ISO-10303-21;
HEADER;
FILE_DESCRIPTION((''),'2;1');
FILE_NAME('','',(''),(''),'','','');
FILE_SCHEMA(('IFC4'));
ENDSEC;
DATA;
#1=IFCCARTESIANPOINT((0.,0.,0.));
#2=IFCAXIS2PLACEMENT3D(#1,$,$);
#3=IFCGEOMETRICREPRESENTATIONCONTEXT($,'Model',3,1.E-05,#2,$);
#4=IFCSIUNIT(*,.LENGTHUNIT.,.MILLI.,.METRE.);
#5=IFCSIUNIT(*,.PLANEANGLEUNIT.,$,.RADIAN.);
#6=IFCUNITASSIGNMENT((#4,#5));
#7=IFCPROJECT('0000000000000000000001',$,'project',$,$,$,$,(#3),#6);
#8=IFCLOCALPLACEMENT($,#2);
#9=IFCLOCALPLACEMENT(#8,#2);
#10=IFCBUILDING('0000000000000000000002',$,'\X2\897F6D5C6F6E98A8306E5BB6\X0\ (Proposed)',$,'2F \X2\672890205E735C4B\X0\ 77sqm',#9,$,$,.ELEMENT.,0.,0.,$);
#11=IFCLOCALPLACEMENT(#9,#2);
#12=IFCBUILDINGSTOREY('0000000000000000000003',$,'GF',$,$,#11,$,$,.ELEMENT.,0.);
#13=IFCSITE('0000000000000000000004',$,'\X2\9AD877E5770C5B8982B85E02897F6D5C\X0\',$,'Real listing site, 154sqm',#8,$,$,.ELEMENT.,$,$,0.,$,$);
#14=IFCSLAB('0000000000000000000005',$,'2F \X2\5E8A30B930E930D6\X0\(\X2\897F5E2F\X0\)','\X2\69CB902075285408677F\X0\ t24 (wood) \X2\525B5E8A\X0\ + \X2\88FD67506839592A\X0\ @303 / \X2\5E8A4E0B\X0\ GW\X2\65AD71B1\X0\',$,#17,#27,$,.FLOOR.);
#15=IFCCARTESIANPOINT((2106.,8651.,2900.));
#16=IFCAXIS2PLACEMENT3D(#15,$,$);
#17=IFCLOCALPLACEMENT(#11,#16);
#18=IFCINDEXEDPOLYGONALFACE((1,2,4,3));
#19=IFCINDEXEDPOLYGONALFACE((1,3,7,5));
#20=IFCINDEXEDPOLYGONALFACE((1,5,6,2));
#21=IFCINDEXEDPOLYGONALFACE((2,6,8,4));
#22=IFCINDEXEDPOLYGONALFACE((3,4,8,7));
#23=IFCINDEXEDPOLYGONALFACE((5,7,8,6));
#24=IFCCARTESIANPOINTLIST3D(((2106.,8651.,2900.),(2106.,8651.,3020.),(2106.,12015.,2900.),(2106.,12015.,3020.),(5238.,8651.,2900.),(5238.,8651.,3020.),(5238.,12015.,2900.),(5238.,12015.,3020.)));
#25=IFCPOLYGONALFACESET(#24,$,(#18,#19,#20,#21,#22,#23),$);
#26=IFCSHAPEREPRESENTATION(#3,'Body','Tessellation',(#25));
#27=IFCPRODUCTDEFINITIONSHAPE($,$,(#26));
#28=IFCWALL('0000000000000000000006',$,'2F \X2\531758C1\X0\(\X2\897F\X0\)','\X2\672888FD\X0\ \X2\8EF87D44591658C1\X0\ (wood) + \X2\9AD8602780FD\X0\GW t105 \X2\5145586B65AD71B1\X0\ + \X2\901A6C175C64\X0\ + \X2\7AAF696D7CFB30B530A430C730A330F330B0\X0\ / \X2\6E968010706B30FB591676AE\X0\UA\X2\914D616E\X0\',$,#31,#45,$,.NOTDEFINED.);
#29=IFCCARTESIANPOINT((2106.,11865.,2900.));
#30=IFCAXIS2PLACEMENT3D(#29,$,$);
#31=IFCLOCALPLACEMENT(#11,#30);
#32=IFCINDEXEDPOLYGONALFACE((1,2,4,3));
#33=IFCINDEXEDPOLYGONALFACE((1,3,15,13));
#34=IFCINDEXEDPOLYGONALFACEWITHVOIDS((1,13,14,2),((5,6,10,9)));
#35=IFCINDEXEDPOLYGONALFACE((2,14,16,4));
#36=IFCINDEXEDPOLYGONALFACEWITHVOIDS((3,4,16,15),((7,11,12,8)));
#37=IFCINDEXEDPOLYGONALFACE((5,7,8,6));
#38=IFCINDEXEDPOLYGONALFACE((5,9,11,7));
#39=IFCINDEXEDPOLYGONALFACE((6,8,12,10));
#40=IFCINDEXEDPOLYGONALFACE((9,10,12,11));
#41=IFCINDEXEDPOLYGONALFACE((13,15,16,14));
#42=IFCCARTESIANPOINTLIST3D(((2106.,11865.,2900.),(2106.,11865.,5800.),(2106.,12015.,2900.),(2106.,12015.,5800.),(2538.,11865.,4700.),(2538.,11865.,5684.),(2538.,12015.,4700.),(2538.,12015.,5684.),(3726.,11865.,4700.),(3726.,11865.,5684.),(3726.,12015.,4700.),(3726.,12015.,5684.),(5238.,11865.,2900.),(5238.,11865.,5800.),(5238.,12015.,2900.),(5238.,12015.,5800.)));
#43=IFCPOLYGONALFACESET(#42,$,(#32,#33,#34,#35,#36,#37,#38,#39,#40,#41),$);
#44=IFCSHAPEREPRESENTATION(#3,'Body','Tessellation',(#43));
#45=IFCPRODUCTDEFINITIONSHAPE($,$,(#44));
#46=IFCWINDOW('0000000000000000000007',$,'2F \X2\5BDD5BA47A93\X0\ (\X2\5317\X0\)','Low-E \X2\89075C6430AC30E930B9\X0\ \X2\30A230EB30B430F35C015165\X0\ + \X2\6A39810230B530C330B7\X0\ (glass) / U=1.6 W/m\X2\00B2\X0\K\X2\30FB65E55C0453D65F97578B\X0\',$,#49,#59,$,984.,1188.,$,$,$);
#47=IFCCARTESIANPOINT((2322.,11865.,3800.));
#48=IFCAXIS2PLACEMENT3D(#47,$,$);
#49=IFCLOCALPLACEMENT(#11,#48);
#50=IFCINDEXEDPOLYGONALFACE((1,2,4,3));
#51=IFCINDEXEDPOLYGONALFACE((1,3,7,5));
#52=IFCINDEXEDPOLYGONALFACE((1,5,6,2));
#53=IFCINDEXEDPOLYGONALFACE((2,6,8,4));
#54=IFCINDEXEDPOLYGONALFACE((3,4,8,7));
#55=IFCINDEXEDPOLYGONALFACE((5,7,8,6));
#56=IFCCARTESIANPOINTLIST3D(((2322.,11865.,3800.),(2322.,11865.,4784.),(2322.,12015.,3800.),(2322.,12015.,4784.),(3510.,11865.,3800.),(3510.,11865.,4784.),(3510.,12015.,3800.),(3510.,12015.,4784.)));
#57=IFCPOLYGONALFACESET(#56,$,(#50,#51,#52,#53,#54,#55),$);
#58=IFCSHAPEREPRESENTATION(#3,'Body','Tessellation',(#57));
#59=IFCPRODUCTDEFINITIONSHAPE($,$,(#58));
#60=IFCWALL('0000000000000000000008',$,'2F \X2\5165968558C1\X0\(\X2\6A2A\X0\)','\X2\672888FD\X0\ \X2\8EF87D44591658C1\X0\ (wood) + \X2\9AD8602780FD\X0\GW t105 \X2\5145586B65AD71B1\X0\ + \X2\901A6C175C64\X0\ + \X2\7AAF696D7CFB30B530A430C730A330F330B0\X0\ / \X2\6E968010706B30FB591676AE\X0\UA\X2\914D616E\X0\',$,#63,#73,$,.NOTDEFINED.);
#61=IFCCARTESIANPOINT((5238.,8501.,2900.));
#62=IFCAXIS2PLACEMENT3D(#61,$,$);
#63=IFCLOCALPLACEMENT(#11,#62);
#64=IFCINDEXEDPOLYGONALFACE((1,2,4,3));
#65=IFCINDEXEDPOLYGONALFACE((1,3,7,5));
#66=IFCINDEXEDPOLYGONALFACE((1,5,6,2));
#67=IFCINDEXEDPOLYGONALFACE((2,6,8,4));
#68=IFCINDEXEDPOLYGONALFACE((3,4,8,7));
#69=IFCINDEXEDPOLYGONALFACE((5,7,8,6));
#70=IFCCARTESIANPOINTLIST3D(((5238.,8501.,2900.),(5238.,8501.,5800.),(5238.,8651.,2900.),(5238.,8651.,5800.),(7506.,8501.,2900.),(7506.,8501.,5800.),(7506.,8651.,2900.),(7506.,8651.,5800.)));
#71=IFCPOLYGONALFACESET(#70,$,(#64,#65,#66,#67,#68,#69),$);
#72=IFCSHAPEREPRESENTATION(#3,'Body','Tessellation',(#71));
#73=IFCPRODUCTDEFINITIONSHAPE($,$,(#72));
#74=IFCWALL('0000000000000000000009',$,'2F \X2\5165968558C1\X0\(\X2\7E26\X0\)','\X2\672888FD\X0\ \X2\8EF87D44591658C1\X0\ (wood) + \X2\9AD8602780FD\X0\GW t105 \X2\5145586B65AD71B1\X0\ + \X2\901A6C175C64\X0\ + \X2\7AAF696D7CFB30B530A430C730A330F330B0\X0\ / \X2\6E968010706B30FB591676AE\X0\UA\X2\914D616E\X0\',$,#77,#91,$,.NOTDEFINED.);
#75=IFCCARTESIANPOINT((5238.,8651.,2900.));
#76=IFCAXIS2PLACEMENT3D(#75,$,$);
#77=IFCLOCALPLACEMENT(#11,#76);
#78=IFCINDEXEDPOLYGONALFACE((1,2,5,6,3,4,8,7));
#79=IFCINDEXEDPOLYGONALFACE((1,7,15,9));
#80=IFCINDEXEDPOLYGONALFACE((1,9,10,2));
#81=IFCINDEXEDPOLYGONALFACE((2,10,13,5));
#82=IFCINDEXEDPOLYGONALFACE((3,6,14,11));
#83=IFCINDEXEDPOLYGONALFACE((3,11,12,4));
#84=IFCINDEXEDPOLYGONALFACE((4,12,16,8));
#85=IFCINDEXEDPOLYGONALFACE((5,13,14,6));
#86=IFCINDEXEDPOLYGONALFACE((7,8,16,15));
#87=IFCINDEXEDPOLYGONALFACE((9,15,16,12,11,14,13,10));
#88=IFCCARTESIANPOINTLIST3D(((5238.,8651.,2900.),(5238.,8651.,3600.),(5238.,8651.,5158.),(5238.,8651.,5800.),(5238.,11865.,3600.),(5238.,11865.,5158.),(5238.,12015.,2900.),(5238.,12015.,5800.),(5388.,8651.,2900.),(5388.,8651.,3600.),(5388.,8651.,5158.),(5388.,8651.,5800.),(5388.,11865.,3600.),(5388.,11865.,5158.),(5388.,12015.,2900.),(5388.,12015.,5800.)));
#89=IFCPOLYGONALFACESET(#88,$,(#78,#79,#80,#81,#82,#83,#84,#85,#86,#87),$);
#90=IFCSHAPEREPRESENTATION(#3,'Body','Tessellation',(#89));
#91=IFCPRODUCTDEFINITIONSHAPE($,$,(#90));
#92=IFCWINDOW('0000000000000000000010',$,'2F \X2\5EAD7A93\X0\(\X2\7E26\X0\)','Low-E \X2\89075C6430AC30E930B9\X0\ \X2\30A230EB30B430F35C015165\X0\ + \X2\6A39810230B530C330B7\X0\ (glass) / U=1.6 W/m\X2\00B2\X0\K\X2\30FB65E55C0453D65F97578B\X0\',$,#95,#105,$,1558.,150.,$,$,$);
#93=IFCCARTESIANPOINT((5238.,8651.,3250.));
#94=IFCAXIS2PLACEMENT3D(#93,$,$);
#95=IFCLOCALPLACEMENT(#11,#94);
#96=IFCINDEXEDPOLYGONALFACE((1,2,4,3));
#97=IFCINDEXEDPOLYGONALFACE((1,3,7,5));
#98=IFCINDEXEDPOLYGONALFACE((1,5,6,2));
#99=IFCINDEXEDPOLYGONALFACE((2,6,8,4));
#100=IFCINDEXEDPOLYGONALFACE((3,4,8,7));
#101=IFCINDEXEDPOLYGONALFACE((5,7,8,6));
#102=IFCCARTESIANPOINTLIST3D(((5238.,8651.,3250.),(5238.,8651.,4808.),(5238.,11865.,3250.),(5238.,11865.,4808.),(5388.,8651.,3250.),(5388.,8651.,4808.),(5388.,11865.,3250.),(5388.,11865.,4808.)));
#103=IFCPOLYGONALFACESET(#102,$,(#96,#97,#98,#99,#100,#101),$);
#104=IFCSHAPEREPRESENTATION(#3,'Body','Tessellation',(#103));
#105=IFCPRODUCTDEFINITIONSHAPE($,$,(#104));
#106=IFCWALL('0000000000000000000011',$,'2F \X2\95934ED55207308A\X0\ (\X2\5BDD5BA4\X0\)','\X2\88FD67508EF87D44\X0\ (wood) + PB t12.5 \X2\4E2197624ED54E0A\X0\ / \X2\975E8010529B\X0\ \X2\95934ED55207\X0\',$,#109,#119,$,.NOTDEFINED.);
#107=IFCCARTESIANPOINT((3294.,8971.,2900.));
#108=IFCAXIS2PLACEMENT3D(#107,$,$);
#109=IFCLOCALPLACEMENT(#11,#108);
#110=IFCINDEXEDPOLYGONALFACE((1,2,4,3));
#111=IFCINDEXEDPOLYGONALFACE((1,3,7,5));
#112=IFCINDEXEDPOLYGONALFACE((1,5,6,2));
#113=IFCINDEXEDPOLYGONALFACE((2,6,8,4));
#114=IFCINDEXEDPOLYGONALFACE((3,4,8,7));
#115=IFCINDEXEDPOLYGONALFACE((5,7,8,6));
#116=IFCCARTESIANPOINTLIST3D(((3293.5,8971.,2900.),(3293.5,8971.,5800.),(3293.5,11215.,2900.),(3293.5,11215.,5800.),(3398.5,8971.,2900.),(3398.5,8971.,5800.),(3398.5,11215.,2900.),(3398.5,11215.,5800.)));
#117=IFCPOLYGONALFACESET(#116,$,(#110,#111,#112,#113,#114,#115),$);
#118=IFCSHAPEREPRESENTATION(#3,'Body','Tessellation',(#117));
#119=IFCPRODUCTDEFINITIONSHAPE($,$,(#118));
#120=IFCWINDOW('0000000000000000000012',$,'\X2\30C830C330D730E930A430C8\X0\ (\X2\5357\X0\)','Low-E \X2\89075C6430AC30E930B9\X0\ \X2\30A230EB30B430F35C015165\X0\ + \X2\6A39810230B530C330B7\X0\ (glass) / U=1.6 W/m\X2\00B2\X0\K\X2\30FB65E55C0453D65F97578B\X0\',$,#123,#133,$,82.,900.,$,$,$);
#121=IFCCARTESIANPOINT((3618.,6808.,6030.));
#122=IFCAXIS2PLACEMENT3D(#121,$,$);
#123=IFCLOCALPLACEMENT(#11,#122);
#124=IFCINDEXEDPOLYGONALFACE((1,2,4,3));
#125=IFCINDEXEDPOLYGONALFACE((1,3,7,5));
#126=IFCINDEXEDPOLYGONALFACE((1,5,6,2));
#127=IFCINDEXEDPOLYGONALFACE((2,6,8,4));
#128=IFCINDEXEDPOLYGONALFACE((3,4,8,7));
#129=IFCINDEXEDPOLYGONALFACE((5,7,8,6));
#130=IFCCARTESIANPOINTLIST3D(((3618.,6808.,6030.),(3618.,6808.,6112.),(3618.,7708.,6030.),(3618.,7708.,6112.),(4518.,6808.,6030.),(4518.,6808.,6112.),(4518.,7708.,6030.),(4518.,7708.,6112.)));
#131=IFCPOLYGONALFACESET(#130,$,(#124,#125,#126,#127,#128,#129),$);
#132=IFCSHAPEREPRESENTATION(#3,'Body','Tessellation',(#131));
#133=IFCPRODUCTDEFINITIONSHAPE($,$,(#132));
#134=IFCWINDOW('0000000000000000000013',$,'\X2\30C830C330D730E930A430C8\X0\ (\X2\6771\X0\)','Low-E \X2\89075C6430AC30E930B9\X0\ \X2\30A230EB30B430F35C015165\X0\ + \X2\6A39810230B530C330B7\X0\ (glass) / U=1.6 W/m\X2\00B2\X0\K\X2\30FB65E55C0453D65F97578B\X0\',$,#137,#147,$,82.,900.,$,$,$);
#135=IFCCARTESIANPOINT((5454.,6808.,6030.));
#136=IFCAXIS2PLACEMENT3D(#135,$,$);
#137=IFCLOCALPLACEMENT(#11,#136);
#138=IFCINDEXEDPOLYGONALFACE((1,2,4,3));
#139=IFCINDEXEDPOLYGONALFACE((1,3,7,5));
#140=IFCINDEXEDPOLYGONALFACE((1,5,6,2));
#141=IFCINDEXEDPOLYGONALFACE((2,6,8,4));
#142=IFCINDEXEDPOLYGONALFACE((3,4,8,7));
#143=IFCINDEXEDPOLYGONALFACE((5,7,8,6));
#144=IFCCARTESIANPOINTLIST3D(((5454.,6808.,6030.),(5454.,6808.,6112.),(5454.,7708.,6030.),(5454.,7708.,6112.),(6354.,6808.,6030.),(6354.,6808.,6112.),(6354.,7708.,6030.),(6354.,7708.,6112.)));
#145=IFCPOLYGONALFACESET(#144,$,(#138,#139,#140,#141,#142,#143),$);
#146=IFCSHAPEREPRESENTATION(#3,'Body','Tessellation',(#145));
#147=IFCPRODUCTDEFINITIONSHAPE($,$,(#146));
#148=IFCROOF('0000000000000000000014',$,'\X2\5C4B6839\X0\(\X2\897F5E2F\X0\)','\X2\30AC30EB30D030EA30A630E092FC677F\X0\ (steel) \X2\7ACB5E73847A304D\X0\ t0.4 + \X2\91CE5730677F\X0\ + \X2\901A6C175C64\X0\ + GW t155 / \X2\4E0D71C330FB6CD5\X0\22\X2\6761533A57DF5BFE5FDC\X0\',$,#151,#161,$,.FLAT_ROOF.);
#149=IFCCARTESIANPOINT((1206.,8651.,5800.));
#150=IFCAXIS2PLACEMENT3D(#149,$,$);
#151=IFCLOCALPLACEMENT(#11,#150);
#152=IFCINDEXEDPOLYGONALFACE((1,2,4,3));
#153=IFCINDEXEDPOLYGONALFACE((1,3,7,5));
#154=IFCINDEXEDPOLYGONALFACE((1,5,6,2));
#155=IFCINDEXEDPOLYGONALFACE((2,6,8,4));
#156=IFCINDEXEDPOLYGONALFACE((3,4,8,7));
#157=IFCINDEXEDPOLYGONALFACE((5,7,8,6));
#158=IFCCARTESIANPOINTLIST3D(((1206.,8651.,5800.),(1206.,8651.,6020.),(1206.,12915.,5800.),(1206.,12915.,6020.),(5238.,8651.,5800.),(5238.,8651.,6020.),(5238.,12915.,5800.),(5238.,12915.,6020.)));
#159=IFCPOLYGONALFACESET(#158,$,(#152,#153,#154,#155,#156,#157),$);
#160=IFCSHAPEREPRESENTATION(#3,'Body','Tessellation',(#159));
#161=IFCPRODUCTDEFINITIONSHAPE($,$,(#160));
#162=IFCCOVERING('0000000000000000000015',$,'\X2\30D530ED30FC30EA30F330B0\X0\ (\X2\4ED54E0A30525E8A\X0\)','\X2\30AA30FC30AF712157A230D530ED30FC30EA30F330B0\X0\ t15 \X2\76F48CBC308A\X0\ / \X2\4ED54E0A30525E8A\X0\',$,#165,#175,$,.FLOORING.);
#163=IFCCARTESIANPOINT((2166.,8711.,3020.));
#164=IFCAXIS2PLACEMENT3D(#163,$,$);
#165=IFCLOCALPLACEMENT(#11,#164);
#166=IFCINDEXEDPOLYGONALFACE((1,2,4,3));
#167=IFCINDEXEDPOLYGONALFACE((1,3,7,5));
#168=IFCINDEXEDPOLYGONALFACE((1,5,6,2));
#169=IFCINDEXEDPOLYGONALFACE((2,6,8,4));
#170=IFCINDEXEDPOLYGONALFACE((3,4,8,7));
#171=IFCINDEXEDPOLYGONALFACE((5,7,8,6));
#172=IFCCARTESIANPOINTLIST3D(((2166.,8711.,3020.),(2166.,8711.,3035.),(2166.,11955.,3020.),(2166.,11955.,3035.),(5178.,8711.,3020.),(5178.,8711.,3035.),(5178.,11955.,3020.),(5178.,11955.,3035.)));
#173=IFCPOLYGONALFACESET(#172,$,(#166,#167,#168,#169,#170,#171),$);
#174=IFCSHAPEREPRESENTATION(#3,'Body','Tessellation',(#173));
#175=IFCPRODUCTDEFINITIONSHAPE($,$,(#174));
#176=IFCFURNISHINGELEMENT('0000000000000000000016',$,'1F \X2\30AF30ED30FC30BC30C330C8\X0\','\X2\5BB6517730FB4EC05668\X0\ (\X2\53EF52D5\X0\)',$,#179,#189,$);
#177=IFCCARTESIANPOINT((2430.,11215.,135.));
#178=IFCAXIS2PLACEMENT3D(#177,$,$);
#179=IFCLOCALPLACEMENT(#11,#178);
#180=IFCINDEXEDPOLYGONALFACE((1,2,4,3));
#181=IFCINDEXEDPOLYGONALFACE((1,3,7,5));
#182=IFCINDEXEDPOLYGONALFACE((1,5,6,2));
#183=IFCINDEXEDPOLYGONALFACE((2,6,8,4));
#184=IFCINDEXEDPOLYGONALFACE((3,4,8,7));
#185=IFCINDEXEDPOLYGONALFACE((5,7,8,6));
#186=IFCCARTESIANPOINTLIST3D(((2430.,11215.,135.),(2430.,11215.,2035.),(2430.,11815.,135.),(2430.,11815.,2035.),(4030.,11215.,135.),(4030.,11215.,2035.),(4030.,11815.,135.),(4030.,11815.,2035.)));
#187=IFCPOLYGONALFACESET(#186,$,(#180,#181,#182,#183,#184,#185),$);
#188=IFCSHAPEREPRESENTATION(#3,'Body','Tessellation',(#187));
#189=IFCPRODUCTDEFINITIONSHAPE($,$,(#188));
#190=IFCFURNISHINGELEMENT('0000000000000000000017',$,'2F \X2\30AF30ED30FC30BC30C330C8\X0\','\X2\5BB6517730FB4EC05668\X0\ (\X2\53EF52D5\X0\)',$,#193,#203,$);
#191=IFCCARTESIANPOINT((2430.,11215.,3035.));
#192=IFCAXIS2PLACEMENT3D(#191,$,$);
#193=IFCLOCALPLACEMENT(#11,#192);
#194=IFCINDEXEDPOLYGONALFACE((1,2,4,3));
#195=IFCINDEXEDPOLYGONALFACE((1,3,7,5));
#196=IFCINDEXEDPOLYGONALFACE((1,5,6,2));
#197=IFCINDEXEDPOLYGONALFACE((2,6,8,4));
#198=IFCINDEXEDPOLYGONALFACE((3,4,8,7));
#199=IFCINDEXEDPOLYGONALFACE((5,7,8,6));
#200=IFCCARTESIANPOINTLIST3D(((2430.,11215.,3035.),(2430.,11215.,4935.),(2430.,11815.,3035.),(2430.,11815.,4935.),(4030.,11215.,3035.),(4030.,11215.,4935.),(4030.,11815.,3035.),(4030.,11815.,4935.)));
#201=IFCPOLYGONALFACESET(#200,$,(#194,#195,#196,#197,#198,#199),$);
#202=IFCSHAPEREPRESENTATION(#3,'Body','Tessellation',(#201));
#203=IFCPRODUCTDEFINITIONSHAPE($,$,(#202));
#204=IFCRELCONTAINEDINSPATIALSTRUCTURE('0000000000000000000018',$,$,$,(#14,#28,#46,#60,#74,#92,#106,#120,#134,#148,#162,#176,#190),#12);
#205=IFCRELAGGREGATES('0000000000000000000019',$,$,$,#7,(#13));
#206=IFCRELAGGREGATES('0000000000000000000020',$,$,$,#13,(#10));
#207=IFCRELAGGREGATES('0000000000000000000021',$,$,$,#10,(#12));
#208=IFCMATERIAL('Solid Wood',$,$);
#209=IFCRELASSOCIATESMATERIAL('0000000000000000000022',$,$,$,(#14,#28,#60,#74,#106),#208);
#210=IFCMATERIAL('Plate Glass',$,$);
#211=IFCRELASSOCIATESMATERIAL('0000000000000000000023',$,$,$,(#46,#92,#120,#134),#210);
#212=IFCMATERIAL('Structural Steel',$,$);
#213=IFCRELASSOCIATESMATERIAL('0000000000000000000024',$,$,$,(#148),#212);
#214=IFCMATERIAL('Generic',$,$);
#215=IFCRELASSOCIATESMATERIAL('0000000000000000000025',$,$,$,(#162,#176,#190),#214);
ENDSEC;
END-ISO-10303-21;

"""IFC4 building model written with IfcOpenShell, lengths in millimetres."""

from ifc_helpers import new_model, si_unit, frame, frame_2d, origin, place, context, project, spatial, rectangle, extrude, material, element, fill, save


model = new_model("IFC4")

# Units and contexts
model_context = context("Model", 3, precision=1e-05, world=origin())
ifc_project = project(units=[si_unit("LENGTHUNIT", "METRE", prefix="MILLI"), si_unit("PLANEANGLEUNIT", "RADIAN")], contexts=[model_context])

# Site, building, storey
site_placement = place(None, origin())
site = spatial("IfcSite", under=ifc_project, at=site_placement, Name="高知県安芸市西浜", ObjectType="Real listing site, 154sqm", CompositionType="ELEMENT", RefElevation=0.0)
building_placement = place(site_placement, origin())
building = spatial("IfcBuilding", under=site, at=building_placement, Name="西浜潮風の家 (Proposed)", ObjectType="2F 木造平屋 77sqm", CompositionType="ELEMENT", ElevationOfRefHeight=0.0, ElevationOfTerrain=0.0)
storey_placement = place(building_placement, origin())
storey = spatial("IfcBuildingStorey", under=building, at=storey_placement, Name="GF", CompositionType="ELEMENT", Elevation=0.0)

# Slab
ifc_material_1 = material(Name="Solid Wood")
slab_placement = place(storey_placement, frame((2106.0, 8651.0, 2900.0)))
element("IfcSlab", 1, at=slab_placement, inside=storey, material=ifc_material_1, Name="2F 床スラブ(西帯)", Description="構造用合板 t24 (wood) 剛床 + 製材根太 @303 / 床下 GW断熱", PredefinedType="FLOOR", context=model_context, shape_type="SweptSolid", body=[
    extrude(rectangle(XDim=3132.0, YDim=3364.0, at=frame_2d((1566.0, 1682.0))), frame((2106.0, 8651.0, 2900.0)), (0.0, 0.0, 1.0), 120.0),
])

# Wall, opening, window
wall_1_placement = place(storey_placement, frame((2106.0, 11865.0, 2900.0)))
wall_1 = element("IfcWall", 2, at=wall_1_placement, inside=storey, material=ifc_material_1, Name="2F 北壁(西)", Description="木製 軸組外壁 (wood) + 高性能GW t105 充填断熱 + 通気層 + 窯業系サイディング / 準耐火・外皮UA配慮", PredefinedType="NOTDEFINED", context=model_context, shape_type="SweptSolid", body=[
    extrude(rectangle(XDim=3132.0, YDim=150.0, at=frame_2d((1566.0, 75.0))), frame((2106.0, 11865.0, 2900.0)), (0.0, 0.0, 1.0), 2900.0),
])
opening_1_placement = place(storey_placement, frame((2322.0, 11865.0, 3800.0)))
opening_1 = element("IfcOpeningElement", 3, at=opening_1_placement, cuts=wall_1, PredefinedType="NOTDEFINED", context=model_context, shape_type="SweptSolid", body=[
    extrude(rectangle(XDim=1188.0, YDim=150.0, at=frame_2d((594.0, 75.0))), frame((2322.0, 11865.0, 3800.0)), (0.0, 0.0, 1.0), 984.0),
])
ifc_material_2 = material(Name="Plate Glass")
window_1_placement = place(storey_placement, frame((2322.0, 11865.0, 3800.0)))
window_1 = element("IfcWindow", 4, at=window_1_placement, inside=storey, material=ifc_material_2, Name="2F 寝室窓 (北)", Description="Low-E 複層ガラス アルゴン封入 + 樹脂サッシ (glass) / U=1.6 W/m²K・日射取得型", OverallHeight=984.0, OverallWidth=1188.0, context=model_context, shape_type="SweptSolid", body=[
    extrude(rectangle(XDim=1188.0, YDim=150.0, at=frame_2d((594.0, 75.0))), frame((2322.0, 11865.0, 3800.0)), (0.0, 0.0, 1.0), 984.0),
])
fill(opening_1, window_1)

# Wall
wall_2_placement = place(storey_placement, frame((5238.0, 8501.0, 2900.0)))
element("IfcWall", 5, at=wall_2_placement, inside=storey, material=ifc_material_1, Name="2F 入隅壁(横)", Description="木製 軸組外壁 (wood) + 高性能GW t105 充填断熱 + 通気層 + 窯業系サイディング / 準耐火・外皮UA配慮", PredefinedType="NOTDEFINED", context=model_context, shape_type="SweptSolid", body=[
    extrude(rectangle(XDim=2268.0, YDim=150.0, at=frame_2d((1134.0, 75.0))), frame((5238.0, 8501.0, 2900.0)), (0.0, 0.0, 1.0), 2900.0),
])

# Wall, opening, window
wall_3_placement = place(storey_placement, frame((5238.0, 8651.0, 2900.0)))
wall_3 = element("IfcWall", 6, at=wall_3_placement, inside=storey, material=ifc_material_1, Name="2F 入隅壁(縦)", Description="木製 軸組外壁 (wood) + 高性能GW t105 充填断熱 + 通気層 + 窯業系サイディング / 準耐火・外皮UA配慮", PredefinedType="NOTDEFINED", context=model_context, shape_type="SweptSolid", body=[
    extrude(rectangle(XDim=150.0, YDim=3364.0, at=frame_2d((75.0, 1682.0))), frame((5238.0, 8651.0, 2900.0)), (0.0, 0.0, 1.0), 2900.0),
])
opening_2_placement = place(storey_placement, frame((5238.0, 8651.0, 3250.0)))
opening_2 = element("IfcOpeningElement", 7, at=opening_2_placement, cuts=wall_3, PredefinedType="NOTDEFINED", context=model_context, shape_type="SweptSolid", body=[
    extrude(rectangle(XDim=150.0, YDim=3214.0, at=frame_2d((75.0, 1607.0))), frame((5238.0, 8651.0, 3250.0)), (0.0, 0.0, 1.0), 1558.0),
])
window_2_placement = place(storey_placement, frame((5238.0, 8651.0, 3250.0)))
window_2 = element("IfcWindow", 8, at=window_2_placement, inside=storey, material=ifc_material_2, Name="2F 庭窓(縦)", Description="Low-E 複層ガラス アルゴン封入 + 樹脂サッシ (glass) / U=1.6 W/m²K・日射取得型", OverallHeight=1558.0, OverallWidth=150.0, context=model_context, shape_type="SweptSolid", body=[
    extrude(rectangle(XDim=150.0, YDim=3214.0, at=frame_2d((75.0, 1607.0))), frame((5238.0, 8651.0, 3250.0)), (0.0, 0.0, 1.0), 1558.0),
])
fill(opening_2, window_2)

# Wall
wall_4_placement = place(storey_placement, frame((3294.0, 8971.0, 2900.0)))
element("IfcWall", 9, at=wall_4_placement, inside=storey, material=ifc_material_1, Name="2F 間仕切り (寝室)", Description="製材軸組 (wood) + PB t12.5 両面仕上 / 非耐力 間仕切", PredefinedType="NOTDEFINED", context=model_context, shape_type="SweptSolid", body=[
    extrude(rectangle(XDim=105.0, YDim=2244.0, at=frame_2d((52.0, 1122.0))), frame((3294.0, 8971.0, 2900.0)), (0.0, 0.0, 1.0), 2900.0),
])

# Windows
window_3_placement = place(storey_placement, frame((3618.0, 6808.0, 6030.0)))
element("IfcWindow", 10, at=window_3_placement, inside=storey, material=ifc_material_2, Name="トップライト (南)", Description="Low-E 複層ガラス アルゴン封入 + 樹脂サッシ (glass) / U=1.6 W/m²K・日射取得型", OverallHeight=82.0, OverallWidth=900.0, context=model_context, shape_type="SweptSolid", body=[
    extrude(rectangle(XDim=900.0, YDim=900.0, at=frame_2d((450.0, 450.0))), frame((3618.0, 6808.0, 6030.0)), (0.0, 0.0, 1.0), 82.0),
])
window_4_placement = place(storey_placement, frame((5454.0, 6808.0, 6030.0)))
element("IfcWindow", 11, at=window_4_placement, inside=storey, material=ifc_material_2, Name="トップライト (東)", Description="Low-E 複層ガラス アルゴン封入 + 樹脂サッシ (glass) / U=1.6 W/m²K・日射取得型", OverallHeight=82.0, OverallWidth=900.0, context=model_context, shape_type="SweptSolid", body=[
    extrude(rectangle(XDim=900.0, YDim=900.0, at=frame_2d((450.0, 450.0))), frame((5454.0, 6808.0, 6030.0)), (0.0, 0.0, 1.0), 82.0),
])

# Roof
ifc_material_3 = material(Name="Structural Steel")
for number, where, name in (
    (12, (1206.0, 8651.0, 5800.0), "屋根(西帯)"),
):
    element("IfcRoof", number, at=place(storey_placement, frame(where)), inside=storey, material=ifc_material_3, Name=name, Description="ガルバリウム鋼板 (steel) 立平葺き t0.4 + 野地板 + 通気層 + GW t155 / 不燃・法22条区域対応", PredefinedType="FLAT_ROOF", context=model_context, shape_type="SweptSolid", body=[
        extrude(rectangle(XDim=4032.0, YDim=4264.0, at=frame_2d((2016.0, 2132.0))), frame((1206.0, 8651.0, 5800.0)), (0.0, 0.0, 1.0), 220.0),
    ])

# Covering
ifc_material_4 = material(Name="Generic")
covering_placement = place(storey_placement, frame((2166.0, 8711.0, 3020.0)))
element("IfcCovering", 13, at=covering_placement, inside=storey, material=ifc_material_4, Name="フローリング (仕上げ床)", Description="オーク無垢フローリング t15 直貼り / 仕上げ床", PredefinedType="FLOORING", context=model_context, shape_type="SweptSolid", body=[
    extrude(rectangle(XDim=3012.0, YDim=3244.0, at=frame_2d((1506.0, 1622.0))), frame((2166.0, 8711.0, 3020.0)), (0.0, 0.0, 1.0), 15.0),
])

# Furnishing elements
furnishing_1_placement = place(storey_placement, frame((2430.0, 11215.0, 135.0)))
element("IfcFurnishingElement", 14, at=furnishing_1_placement, inside=storey, material=ifc_material_4, Name="1F クローゼット", Description="家具・什器 (可動)", context=model_context, shape_type="SweptSolid", body=[
    extrude(rectangle(XDim=1600.0, YDim=600.0, at=frame_2d((800.0, 300.0))), frame((2430.0, 11215.0, 135.0)), (0.0, 0.0, 1.0), 1900.0),
])
furnishing_2_placement = place(storey_placement, frame((2430.0, 11215.0, 3035.0)))
element("IfcFurnishingElement", 15, at=furnishing_2_placement, inside=storey, material=ifc_material_4, Name="2F クローゼット", Description="家具・什器 (可動)", context=model_context, shape_type="SweptSolid", body=[
    extrude(rectangle(XDim=1600.0, YDim=600.0, at=frame_2d((800.0, 300.0))), frame((2430.0, 11215.0, 3035.0)), (0.0, 0.0, 1.0), 1900.0),
])

save(model, "model.ifc")
